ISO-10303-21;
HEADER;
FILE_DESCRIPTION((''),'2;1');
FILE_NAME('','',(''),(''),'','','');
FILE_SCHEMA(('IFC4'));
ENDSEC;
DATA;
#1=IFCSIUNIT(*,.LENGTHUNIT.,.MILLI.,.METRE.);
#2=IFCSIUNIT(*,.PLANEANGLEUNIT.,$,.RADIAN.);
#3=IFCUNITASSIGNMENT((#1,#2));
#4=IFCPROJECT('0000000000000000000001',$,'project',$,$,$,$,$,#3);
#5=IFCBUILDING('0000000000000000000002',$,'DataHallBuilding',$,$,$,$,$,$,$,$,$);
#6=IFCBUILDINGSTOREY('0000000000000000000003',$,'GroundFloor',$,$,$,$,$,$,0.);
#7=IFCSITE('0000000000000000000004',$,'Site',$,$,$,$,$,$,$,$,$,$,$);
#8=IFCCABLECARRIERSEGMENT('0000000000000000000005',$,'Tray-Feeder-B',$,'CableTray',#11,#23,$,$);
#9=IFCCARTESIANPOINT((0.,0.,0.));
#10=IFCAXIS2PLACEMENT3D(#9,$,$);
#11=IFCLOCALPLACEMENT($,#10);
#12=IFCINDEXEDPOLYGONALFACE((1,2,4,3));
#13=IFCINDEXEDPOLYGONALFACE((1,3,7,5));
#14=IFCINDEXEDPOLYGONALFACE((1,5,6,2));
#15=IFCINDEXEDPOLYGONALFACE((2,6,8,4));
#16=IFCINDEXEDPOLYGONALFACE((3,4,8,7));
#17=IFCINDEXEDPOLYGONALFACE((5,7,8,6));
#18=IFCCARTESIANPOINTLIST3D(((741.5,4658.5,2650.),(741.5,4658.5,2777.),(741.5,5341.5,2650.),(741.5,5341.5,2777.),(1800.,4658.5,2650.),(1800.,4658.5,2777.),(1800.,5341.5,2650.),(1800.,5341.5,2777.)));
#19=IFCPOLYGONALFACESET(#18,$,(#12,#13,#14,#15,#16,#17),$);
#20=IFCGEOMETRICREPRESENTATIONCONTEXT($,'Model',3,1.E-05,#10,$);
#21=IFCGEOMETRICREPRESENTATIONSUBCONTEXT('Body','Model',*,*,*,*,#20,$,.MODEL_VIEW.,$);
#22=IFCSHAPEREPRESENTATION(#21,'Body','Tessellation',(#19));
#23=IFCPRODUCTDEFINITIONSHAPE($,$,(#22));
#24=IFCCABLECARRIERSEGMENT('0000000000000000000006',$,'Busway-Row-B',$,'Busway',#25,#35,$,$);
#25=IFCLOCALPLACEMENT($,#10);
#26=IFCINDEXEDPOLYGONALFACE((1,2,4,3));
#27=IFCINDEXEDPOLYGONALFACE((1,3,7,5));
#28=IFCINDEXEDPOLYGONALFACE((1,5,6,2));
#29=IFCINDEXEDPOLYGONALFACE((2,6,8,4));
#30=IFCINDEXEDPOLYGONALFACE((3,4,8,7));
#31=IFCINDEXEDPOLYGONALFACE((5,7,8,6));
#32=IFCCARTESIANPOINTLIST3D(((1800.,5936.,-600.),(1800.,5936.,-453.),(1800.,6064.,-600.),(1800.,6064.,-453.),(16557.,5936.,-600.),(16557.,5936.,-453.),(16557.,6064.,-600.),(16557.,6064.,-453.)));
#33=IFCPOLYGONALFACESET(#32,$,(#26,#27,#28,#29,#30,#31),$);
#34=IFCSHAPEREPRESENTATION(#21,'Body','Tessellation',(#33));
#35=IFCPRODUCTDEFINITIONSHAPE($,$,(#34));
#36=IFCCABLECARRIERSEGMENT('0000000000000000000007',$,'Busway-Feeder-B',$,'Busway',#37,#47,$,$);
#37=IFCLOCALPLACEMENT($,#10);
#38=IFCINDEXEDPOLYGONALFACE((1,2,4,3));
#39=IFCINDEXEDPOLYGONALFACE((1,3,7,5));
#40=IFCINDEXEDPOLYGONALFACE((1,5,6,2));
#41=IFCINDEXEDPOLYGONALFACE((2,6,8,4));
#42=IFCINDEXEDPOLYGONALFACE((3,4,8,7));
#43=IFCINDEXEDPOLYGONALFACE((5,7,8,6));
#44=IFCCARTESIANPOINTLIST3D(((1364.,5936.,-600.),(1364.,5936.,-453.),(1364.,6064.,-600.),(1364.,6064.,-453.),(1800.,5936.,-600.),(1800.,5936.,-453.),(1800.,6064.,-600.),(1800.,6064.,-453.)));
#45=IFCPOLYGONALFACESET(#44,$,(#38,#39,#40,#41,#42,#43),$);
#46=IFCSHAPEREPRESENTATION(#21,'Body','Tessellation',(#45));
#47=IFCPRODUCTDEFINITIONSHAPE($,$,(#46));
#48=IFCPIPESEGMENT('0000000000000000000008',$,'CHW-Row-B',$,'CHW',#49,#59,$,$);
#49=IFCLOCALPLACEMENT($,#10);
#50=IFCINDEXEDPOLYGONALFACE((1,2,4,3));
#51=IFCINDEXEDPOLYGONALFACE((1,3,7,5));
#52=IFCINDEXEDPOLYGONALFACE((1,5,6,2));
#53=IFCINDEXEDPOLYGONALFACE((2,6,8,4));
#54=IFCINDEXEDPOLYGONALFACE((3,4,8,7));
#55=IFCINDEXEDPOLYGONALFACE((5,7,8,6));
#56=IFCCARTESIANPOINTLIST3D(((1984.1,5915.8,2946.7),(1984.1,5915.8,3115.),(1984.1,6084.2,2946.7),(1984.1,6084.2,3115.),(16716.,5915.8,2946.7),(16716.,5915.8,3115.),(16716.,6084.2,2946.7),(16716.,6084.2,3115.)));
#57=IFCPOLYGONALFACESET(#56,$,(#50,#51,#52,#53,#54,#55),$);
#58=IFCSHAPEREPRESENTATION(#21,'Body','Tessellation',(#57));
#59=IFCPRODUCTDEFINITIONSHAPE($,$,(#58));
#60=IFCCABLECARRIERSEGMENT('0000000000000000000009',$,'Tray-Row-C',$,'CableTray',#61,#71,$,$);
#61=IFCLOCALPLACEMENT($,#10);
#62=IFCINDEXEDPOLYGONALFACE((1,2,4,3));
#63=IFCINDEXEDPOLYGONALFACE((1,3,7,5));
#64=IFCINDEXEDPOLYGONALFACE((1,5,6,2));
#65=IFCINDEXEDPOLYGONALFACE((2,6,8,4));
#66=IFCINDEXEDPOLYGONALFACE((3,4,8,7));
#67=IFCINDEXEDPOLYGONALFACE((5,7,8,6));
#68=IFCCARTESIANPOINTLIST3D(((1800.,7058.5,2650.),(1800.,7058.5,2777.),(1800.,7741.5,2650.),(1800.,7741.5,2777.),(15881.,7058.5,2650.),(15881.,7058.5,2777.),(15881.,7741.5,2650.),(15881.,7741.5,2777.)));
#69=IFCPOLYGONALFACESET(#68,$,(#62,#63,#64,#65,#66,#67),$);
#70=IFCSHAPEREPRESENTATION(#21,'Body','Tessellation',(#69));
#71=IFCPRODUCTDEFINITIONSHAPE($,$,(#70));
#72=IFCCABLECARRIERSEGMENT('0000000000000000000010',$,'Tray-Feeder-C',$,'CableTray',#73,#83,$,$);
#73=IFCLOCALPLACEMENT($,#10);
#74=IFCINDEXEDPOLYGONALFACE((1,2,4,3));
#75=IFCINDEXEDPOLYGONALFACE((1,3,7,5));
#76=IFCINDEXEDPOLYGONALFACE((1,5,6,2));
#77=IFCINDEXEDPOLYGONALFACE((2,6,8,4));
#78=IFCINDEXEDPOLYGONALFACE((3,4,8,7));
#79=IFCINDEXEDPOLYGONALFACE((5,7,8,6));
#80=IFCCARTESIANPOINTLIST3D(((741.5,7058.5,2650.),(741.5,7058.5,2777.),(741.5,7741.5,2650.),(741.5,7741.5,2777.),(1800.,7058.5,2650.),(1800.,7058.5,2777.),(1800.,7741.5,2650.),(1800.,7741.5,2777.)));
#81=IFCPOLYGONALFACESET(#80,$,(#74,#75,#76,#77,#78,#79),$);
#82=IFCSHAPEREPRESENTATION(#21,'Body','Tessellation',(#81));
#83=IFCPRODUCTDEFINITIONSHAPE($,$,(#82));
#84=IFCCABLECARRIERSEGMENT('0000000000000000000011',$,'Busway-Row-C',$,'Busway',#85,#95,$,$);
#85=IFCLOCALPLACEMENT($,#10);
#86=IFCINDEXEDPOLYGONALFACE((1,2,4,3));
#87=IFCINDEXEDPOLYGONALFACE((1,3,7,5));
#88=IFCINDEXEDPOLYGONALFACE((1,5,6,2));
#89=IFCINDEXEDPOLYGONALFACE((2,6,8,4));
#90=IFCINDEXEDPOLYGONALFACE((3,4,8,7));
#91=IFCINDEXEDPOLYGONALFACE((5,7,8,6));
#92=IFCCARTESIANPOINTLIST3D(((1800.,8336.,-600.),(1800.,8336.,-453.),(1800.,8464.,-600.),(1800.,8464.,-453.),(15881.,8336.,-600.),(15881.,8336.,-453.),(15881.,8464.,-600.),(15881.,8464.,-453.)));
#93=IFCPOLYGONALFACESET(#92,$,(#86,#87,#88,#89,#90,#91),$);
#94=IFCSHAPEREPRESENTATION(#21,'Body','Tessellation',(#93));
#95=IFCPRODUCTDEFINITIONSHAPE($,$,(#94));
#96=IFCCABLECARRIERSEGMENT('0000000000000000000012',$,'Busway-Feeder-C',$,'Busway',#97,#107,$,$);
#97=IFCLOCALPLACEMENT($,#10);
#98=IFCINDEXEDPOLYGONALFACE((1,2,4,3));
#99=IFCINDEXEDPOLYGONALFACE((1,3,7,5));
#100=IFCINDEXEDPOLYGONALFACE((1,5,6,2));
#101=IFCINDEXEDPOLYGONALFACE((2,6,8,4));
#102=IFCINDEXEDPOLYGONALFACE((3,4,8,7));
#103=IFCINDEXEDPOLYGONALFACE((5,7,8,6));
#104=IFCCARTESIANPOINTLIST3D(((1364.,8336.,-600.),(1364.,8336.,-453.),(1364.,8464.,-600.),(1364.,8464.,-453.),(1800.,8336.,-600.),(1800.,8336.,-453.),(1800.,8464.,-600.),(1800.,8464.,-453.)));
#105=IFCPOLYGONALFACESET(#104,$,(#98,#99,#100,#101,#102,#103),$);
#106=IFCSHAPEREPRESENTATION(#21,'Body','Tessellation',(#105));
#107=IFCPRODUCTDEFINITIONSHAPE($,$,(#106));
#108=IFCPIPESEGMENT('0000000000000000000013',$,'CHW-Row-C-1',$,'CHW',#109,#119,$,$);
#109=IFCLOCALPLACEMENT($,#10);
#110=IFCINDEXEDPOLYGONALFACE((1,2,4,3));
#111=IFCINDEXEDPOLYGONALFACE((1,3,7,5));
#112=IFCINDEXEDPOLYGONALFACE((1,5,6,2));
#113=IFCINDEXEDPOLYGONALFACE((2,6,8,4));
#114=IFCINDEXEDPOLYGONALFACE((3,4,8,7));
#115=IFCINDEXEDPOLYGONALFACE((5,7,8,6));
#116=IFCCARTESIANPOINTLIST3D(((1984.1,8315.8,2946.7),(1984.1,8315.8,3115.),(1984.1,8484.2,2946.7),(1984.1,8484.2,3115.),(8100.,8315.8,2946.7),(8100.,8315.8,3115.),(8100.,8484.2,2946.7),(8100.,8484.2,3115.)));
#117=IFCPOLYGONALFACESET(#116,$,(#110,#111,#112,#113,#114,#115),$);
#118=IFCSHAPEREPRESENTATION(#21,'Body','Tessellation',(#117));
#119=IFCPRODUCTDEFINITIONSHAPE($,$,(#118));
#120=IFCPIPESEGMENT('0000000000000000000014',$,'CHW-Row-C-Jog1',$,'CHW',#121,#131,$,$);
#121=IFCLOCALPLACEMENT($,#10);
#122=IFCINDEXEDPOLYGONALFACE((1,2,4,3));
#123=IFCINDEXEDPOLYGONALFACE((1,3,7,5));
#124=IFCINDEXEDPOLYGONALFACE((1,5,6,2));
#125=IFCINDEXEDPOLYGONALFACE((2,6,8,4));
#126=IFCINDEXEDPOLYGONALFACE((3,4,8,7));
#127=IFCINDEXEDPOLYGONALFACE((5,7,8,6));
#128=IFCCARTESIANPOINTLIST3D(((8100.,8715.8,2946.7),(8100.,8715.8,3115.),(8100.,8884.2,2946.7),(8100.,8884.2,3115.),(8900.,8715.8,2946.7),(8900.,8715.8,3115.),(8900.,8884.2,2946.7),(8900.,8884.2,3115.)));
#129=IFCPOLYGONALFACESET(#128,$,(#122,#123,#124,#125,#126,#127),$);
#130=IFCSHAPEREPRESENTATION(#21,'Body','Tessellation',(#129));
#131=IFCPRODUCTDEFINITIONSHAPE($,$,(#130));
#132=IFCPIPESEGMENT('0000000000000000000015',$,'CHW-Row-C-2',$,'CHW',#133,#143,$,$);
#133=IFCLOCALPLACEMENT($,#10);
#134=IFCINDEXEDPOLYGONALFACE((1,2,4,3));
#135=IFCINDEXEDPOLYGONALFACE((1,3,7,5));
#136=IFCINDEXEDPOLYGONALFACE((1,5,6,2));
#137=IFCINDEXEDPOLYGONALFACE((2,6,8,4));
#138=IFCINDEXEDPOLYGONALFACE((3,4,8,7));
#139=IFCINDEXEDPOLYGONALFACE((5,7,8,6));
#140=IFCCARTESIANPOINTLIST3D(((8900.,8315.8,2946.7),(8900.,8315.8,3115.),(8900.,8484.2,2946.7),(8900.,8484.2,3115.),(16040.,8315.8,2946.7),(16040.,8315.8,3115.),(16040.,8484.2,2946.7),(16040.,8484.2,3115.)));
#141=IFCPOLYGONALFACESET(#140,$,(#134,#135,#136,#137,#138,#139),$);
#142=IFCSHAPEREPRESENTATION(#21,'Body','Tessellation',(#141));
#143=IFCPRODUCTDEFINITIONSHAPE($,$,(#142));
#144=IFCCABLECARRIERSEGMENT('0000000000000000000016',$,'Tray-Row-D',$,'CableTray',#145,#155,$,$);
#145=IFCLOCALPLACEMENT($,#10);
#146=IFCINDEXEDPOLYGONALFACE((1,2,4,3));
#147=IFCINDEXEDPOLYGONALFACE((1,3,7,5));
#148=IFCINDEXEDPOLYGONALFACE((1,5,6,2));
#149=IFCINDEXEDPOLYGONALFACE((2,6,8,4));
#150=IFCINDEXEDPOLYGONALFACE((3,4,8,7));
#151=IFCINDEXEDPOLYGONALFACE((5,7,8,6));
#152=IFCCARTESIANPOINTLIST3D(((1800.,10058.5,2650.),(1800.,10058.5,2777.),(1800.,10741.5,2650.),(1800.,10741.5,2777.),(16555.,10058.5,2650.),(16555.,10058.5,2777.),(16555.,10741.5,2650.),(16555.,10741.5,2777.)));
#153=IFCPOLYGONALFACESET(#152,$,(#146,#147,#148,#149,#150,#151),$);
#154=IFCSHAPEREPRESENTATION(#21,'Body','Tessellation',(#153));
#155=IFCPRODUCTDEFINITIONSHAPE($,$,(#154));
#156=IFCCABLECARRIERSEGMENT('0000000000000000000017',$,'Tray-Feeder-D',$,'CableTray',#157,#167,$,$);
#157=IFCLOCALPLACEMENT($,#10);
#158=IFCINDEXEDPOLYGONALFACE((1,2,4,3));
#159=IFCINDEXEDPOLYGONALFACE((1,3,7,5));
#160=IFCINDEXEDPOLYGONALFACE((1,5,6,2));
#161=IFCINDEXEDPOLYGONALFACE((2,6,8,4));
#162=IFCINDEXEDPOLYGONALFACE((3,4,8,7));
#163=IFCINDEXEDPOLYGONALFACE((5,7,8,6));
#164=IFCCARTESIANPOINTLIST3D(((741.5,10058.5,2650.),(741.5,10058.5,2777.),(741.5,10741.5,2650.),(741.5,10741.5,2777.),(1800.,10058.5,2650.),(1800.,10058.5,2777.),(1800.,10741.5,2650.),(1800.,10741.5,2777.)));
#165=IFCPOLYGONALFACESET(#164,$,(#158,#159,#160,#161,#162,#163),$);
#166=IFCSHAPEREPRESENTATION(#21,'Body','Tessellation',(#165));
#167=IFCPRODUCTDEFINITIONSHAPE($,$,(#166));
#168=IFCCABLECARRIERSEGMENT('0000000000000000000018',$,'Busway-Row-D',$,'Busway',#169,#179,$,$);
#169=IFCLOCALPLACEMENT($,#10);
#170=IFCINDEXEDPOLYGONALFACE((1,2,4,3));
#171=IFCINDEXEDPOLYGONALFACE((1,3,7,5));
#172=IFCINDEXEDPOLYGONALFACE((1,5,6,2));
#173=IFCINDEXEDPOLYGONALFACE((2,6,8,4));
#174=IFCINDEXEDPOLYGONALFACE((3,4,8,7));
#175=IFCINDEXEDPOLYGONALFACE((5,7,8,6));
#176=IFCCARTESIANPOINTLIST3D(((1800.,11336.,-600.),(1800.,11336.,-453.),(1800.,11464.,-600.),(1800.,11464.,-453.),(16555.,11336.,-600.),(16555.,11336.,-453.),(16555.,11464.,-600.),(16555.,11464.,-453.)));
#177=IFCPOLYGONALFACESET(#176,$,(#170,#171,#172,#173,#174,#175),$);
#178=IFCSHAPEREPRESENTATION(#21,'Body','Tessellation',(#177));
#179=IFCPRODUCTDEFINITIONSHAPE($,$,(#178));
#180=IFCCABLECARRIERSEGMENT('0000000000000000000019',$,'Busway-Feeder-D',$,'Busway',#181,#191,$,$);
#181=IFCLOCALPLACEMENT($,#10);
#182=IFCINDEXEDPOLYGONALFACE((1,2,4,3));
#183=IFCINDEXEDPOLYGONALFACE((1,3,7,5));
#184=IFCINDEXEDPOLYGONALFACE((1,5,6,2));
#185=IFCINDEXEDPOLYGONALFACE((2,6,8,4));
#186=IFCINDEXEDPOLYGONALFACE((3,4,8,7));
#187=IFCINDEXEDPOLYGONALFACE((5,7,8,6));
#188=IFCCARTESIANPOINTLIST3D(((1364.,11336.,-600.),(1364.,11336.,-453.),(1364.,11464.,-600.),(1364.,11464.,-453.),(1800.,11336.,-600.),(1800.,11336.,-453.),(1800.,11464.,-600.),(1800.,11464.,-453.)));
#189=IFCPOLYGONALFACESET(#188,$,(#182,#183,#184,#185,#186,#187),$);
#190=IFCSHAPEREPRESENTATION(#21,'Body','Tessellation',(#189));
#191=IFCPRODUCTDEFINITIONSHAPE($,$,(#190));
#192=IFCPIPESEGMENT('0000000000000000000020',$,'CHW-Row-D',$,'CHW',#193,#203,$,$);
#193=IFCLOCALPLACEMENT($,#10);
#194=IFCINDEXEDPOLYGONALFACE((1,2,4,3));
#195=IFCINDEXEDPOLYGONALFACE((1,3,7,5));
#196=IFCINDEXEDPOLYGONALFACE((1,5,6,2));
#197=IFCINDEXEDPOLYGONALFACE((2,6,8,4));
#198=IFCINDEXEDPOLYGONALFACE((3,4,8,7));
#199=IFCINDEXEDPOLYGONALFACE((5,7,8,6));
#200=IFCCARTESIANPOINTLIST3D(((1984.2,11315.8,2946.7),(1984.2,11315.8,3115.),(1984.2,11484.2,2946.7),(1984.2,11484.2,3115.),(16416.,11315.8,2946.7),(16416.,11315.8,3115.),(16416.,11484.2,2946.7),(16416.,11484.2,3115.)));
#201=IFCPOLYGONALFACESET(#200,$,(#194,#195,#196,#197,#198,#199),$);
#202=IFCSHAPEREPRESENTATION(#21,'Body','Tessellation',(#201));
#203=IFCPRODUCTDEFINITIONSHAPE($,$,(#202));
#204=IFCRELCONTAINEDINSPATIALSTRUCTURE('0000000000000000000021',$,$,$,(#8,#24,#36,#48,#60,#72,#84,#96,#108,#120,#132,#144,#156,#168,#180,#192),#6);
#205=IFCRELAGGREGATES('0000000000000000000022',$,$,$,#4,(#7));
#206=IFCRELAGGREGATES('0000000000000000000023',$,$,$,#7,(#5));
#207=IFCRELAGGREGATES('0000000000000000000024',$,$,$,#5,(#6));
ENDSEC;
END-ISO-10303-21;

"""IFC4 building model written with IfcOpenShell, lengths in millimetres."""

from ifc_helpers import new_model, si_unit, frame, origin, place, context, subcontext, project, spatial, rectangle, extrude, element, save


model = new_model("IFC4")

# Units and contexts
model_context = context("Model", 3, precision=1e-05, world=origin())
body_context = subcontext(model_context, "Body", "Model", "MODEL_VIEW")
ifc_project = project(units=[si_unit("LENGTHUNIT", "METRE", prefix="MILLI"), si_unit("PLANEANGLEUNIT", "RADIAN")])

# Site, building, storey
site = spatial("IfcSite", under=ifc_project, Name="Site")
building = spatial("IfcBuilding", under=site, Name="DataHallBuilding")
storey = spatial("IfcBuildingStorey", under=building, Name="GroundFloor", Elevation=0.0)

# Cable carrier segments
cable_carrier_segment_1_placement = place(None, origin())
element("IfcCableCarrierSegment", 1, at=cable_carrier_segment_1_placement, inside=storey, Name="Tray-Feeder-B", ObjectType="CableTray", context=body_context, shape_type="SweptSolid", body=[
    extrude(rectangle(XDim=1058.5, YDim=683.0), frame((1270.8, 5000.0, 2650.0), z_axis=(0.0, 0.0, 1.0), x_axis=(1.0, 0.0, 0.0)), (0.0, 0.0, 1.0), 127.0),
])
cable_carrier_segment_2_placement = place(None, origin())
element("IfcCableCarrierSegment", 2, at=cable_carrier_segment_2_placement, inside=storey, Name="Busway-Row-B", ObjectType="Busway", context=body_context, shape_type="SweptSolid", body=[
    extrude(rectangle(XDim=14757.0, YDim=128.0), frame((9178.5, 6000.0, -600.0), z_axis=(0.0, 0.0, 1.0), x_axis=(1.0, 0.0, 0.0)), (0.0, 0.0, 1.0), 147.0),
])
cable_carrier_segment_3_placement = place(None, origin())
element("IfcCableCarrierSegment", 3, at=cable_carrier_segment_3_placement, inside=storey, Name="Busway-Feeder-B", ObjectType="Busway", context=body_context, shape_type="SweptSolid", body=[
    extrude(rectangle(XDim=436.0, YDim=128.0), frame((1582.0, 6000.0, -600.0), z_axis=(0.0, 0.0, 1.0), x_axis=(1.0, 0.0, 0.0)), (0.0, 0.0, 1.0), 147.0),
])

# Pipe segment
pipe_segment_1_placement = place(None, origin())
element("IfcPipeSegment", 4, at=pipe_segment_1_placement, inside=storey, Name="CHW-Row-B", ObjectType="CHW", context=body_context, shape_type="SweptSolid", body=[
    extrude(rectangle(XDim=14731.9, YDim=168.3), frame((9350.1, 6000.0, 2946.7), z_axis=(0.0, 0.0, 1.0), x_axis=(1.0, 0.0, 0.0)), (0.0, 0.0, 1.0), 168.3),
])

# Cable carrier segments
cable_carrier_segment_4_placement = place(None, origin())
element("IfcCableCarrierSegment", 5, at=cable_carrier_segment_4_placement, inside=storey, Name="Tray-Row-C", ObjectType="CableTray", context=body_context, shape_type="SweptSolid", body=[
    extrude(rectangle(XDim=14081.0, YDim=683.0), frame((8840.5, 7400.0, 2650.0), z_axis=(0.0, 0.0, 1.0), x_axis=(1.0, 0.0, 0.0)), (0.0, 0.0, 1.0), 127.0),
])
cable_carrier_segment_5_placement = place(None, origin())
element("IfcCableCarrierSegment", 6, at=cable_carrier_segment_5_placement, inside=storey, Name="Tray-Feeder-C", ObjectType="CableTray", context=body_context, shape_type="SweptSolid", body=[
    extrude(rectangle(XDim=1058.5, YDim=683.0), frame((1270.8, 7400.0, 2650.0), z_axis=(0.0, 0.0, 1.0), x_axis=(1.0, 0.0, 0.0)), (0.0, 0.0, 1.0), 127.0),
])
cable_carrier_segment_6_placement = place(None, origin())
element("IfcCableCarrierSegment", 7, at=cable_carrier_segment_6_placement, inside=storey, Name="Busway-Row-C", ObjectType="Busway", context=body_context, shape_type="SweptSolid", body=[
    extrude(rectangle(XDim=14081.0, YDim=128.0), frame((8840.5, 8400.0, -600.0), z_axis=(0.0, 0.0, 1.0), x_axis=(1.0, 0.0, 0.0)), (0.0, 0.0, 1.0), 147.0),
])
cable_carrier_segment_7_placement = place(None, origin())
element("IfcCableCarrierSegment", 8, at=cable_carrier_segment_7_placement, inside=storey, Name="Busway-Feeder-C", ObjectType="Busway", context=body_context, shape_type="SweptSolid", body=[
    extrude(rectangle(XDim=436.0, YDim=128.0), frame((1582.0, 8400.0, -600.0), z_axis=(0.0, 0.0, 1.0), x_axis=(1.0, 0.0, 0.0)), (0.0, 0.0, 1.0), 147.0),
])

# Pipe segments
pipe_segment_2_placement = place(None, origin())
element("IfcPipeSegment", 9, at=pipe_segment_2_placement, inside=storey, Name="CHW-Row-C-1", ObjectType="CHW", context=body_context, shape_type="SweptSolid", body=[
    extrude(rectangle(XDim=6115.9, YDim=168.3), frame((5042.1, 8400.0, 2946.7), z_axis=(0.0, 0.0, 1.0), x_axis=(1.0, 0.0, 0.0)), (0.0, 0.0, 1.0), 168.3),
])
pipe_segment_3_placement = place(None, origin())
element("IfcPipeSegment", 10, at=pipe_segment_3_placement, inside=storey, Name="CHW-Row-C-Jog1", ObjectType="CHW", context=body_context, shape_type="SweptSolid", body=[
    extrude(rectangle(XDim=800.0, YDim=168.3), frame((8500.0, 8800.0, 2946.7), z_axis=(0.0, 0.0, 1.0), x_axis=(1.0, 0.0, 0.0)), (0.0, 0.0, 1.0), 168.3),
])
pipe_segment_4_placement = place(None, origin())
element("IfcPipeSegment", 11, at=pipe_segment_4_placement, inside=storey, Name="CHW-Row-C-2", ObjectType="CHW", context=body_context, shape_type="SweptSolid", body=[
    extrude(rectangle(XDim=7140.0, YDim=168.3), frame((12470.0, 8400.0, 2946.7), z_axis=(0.0, 0.0, 1.0), x_axis=(1.0, 0.0, 0.0)), (0.0, 0.0, 1.0), 168.3),
])

# Cable carrier segments
cable_carrier_segment_8_placement = place(None, origin())
element("IfcCableCarrierSegment", 12, at=cable_carrier_segment_8_placement, inside=storey, Name="Tray-Row-D", ObjectType="CableTray", context=body_context, shape_type="SweptSolid", body=[
    extrude(rectangle(XDim=14755.0, YDim=683.0), frame((9177.5, 10400.0, 2650.0), z_axis=(0.0, 0.0, 1.0), x_axis=(1.0, 0.0, 0.0)), (0.0, 0.0, 1.0), 127.0),
])
cable_carrier_segment_9_placement = place(None, origin())
element("IfcCableCarrierSegment", 13, at=cable_carrier_segment_9_placement, inside=storey, Name="Tray-Feeder-D", ObjectType="CableTray", context=body_context, shape_type="SweptSolid", body=[
    extrude(rectangle(XDim=1058.5, YDim=683.0), frame((1270.8, 10400.0, 2650.0), z_axis=(0.0, 0.0, 1.0), x_axis=(1.0, 0.0, 0.0)), (0.0, 0.0, 1.0), 127.0),
])
cable_carrier_segment_10_placement = place(None, origin())
element("IfcCableCarrierSegment", 14, at=cable_carrier_segment_10_placement, inside=storey, Name="Busway-Row-D", ObjectType="Busway", context=body_context, shape_type="SweptSolid", body=[
    extrude(rectangle(XDim=14755.0, YDim=128.0), frame((9177.5, 11400.0, -600.0), z_axis=(0.0, 0.0, 1.0), x_axis=(1.0, 0.0, 0.0)), (0.0, 0.0, 1.0), 147.0),
])
cable_carrier_segment_11_placement = place(None, origin())
element("IfcCableCarrierSegment", 15, at=cable_carrier_segment_11_placement, inside=storey, Name="Busway-Feeder-D", ObjectType="Busway", context=body_context, shape_type="SweptSolid", body=[
    extrude(rectangle(XDim=436.0, YDim=128.0), frame((1582.0, 11400.0, -600.0), z_axis=(0.0, 0.0, 1.0), x_axis=(1.0, 0.0, 0.0)), (0.0, 0.0, 1.0), 147.0),
])

# Pipe segment
pipe_segment_5_placement = place(None, origin())
element("IfcPipeSegment", 16, at=pipe_segment_5_placement, inside=storey, Name="CHW-Row-D", ObjectType="CHW", context=body_context, shape_type="SweptSolid", body=[
    extrude(rectangle(XDim=14431.9, YDim=168.3), frame((9200.1, 11400.0, 2946.7), z_axis=(0.0, 0.0, 1.0), x_axis=(1.0, 0.0, 0.0)), (0.0, 0.0, 1.0), 168.3),
])

save(model, "model.ifc")
